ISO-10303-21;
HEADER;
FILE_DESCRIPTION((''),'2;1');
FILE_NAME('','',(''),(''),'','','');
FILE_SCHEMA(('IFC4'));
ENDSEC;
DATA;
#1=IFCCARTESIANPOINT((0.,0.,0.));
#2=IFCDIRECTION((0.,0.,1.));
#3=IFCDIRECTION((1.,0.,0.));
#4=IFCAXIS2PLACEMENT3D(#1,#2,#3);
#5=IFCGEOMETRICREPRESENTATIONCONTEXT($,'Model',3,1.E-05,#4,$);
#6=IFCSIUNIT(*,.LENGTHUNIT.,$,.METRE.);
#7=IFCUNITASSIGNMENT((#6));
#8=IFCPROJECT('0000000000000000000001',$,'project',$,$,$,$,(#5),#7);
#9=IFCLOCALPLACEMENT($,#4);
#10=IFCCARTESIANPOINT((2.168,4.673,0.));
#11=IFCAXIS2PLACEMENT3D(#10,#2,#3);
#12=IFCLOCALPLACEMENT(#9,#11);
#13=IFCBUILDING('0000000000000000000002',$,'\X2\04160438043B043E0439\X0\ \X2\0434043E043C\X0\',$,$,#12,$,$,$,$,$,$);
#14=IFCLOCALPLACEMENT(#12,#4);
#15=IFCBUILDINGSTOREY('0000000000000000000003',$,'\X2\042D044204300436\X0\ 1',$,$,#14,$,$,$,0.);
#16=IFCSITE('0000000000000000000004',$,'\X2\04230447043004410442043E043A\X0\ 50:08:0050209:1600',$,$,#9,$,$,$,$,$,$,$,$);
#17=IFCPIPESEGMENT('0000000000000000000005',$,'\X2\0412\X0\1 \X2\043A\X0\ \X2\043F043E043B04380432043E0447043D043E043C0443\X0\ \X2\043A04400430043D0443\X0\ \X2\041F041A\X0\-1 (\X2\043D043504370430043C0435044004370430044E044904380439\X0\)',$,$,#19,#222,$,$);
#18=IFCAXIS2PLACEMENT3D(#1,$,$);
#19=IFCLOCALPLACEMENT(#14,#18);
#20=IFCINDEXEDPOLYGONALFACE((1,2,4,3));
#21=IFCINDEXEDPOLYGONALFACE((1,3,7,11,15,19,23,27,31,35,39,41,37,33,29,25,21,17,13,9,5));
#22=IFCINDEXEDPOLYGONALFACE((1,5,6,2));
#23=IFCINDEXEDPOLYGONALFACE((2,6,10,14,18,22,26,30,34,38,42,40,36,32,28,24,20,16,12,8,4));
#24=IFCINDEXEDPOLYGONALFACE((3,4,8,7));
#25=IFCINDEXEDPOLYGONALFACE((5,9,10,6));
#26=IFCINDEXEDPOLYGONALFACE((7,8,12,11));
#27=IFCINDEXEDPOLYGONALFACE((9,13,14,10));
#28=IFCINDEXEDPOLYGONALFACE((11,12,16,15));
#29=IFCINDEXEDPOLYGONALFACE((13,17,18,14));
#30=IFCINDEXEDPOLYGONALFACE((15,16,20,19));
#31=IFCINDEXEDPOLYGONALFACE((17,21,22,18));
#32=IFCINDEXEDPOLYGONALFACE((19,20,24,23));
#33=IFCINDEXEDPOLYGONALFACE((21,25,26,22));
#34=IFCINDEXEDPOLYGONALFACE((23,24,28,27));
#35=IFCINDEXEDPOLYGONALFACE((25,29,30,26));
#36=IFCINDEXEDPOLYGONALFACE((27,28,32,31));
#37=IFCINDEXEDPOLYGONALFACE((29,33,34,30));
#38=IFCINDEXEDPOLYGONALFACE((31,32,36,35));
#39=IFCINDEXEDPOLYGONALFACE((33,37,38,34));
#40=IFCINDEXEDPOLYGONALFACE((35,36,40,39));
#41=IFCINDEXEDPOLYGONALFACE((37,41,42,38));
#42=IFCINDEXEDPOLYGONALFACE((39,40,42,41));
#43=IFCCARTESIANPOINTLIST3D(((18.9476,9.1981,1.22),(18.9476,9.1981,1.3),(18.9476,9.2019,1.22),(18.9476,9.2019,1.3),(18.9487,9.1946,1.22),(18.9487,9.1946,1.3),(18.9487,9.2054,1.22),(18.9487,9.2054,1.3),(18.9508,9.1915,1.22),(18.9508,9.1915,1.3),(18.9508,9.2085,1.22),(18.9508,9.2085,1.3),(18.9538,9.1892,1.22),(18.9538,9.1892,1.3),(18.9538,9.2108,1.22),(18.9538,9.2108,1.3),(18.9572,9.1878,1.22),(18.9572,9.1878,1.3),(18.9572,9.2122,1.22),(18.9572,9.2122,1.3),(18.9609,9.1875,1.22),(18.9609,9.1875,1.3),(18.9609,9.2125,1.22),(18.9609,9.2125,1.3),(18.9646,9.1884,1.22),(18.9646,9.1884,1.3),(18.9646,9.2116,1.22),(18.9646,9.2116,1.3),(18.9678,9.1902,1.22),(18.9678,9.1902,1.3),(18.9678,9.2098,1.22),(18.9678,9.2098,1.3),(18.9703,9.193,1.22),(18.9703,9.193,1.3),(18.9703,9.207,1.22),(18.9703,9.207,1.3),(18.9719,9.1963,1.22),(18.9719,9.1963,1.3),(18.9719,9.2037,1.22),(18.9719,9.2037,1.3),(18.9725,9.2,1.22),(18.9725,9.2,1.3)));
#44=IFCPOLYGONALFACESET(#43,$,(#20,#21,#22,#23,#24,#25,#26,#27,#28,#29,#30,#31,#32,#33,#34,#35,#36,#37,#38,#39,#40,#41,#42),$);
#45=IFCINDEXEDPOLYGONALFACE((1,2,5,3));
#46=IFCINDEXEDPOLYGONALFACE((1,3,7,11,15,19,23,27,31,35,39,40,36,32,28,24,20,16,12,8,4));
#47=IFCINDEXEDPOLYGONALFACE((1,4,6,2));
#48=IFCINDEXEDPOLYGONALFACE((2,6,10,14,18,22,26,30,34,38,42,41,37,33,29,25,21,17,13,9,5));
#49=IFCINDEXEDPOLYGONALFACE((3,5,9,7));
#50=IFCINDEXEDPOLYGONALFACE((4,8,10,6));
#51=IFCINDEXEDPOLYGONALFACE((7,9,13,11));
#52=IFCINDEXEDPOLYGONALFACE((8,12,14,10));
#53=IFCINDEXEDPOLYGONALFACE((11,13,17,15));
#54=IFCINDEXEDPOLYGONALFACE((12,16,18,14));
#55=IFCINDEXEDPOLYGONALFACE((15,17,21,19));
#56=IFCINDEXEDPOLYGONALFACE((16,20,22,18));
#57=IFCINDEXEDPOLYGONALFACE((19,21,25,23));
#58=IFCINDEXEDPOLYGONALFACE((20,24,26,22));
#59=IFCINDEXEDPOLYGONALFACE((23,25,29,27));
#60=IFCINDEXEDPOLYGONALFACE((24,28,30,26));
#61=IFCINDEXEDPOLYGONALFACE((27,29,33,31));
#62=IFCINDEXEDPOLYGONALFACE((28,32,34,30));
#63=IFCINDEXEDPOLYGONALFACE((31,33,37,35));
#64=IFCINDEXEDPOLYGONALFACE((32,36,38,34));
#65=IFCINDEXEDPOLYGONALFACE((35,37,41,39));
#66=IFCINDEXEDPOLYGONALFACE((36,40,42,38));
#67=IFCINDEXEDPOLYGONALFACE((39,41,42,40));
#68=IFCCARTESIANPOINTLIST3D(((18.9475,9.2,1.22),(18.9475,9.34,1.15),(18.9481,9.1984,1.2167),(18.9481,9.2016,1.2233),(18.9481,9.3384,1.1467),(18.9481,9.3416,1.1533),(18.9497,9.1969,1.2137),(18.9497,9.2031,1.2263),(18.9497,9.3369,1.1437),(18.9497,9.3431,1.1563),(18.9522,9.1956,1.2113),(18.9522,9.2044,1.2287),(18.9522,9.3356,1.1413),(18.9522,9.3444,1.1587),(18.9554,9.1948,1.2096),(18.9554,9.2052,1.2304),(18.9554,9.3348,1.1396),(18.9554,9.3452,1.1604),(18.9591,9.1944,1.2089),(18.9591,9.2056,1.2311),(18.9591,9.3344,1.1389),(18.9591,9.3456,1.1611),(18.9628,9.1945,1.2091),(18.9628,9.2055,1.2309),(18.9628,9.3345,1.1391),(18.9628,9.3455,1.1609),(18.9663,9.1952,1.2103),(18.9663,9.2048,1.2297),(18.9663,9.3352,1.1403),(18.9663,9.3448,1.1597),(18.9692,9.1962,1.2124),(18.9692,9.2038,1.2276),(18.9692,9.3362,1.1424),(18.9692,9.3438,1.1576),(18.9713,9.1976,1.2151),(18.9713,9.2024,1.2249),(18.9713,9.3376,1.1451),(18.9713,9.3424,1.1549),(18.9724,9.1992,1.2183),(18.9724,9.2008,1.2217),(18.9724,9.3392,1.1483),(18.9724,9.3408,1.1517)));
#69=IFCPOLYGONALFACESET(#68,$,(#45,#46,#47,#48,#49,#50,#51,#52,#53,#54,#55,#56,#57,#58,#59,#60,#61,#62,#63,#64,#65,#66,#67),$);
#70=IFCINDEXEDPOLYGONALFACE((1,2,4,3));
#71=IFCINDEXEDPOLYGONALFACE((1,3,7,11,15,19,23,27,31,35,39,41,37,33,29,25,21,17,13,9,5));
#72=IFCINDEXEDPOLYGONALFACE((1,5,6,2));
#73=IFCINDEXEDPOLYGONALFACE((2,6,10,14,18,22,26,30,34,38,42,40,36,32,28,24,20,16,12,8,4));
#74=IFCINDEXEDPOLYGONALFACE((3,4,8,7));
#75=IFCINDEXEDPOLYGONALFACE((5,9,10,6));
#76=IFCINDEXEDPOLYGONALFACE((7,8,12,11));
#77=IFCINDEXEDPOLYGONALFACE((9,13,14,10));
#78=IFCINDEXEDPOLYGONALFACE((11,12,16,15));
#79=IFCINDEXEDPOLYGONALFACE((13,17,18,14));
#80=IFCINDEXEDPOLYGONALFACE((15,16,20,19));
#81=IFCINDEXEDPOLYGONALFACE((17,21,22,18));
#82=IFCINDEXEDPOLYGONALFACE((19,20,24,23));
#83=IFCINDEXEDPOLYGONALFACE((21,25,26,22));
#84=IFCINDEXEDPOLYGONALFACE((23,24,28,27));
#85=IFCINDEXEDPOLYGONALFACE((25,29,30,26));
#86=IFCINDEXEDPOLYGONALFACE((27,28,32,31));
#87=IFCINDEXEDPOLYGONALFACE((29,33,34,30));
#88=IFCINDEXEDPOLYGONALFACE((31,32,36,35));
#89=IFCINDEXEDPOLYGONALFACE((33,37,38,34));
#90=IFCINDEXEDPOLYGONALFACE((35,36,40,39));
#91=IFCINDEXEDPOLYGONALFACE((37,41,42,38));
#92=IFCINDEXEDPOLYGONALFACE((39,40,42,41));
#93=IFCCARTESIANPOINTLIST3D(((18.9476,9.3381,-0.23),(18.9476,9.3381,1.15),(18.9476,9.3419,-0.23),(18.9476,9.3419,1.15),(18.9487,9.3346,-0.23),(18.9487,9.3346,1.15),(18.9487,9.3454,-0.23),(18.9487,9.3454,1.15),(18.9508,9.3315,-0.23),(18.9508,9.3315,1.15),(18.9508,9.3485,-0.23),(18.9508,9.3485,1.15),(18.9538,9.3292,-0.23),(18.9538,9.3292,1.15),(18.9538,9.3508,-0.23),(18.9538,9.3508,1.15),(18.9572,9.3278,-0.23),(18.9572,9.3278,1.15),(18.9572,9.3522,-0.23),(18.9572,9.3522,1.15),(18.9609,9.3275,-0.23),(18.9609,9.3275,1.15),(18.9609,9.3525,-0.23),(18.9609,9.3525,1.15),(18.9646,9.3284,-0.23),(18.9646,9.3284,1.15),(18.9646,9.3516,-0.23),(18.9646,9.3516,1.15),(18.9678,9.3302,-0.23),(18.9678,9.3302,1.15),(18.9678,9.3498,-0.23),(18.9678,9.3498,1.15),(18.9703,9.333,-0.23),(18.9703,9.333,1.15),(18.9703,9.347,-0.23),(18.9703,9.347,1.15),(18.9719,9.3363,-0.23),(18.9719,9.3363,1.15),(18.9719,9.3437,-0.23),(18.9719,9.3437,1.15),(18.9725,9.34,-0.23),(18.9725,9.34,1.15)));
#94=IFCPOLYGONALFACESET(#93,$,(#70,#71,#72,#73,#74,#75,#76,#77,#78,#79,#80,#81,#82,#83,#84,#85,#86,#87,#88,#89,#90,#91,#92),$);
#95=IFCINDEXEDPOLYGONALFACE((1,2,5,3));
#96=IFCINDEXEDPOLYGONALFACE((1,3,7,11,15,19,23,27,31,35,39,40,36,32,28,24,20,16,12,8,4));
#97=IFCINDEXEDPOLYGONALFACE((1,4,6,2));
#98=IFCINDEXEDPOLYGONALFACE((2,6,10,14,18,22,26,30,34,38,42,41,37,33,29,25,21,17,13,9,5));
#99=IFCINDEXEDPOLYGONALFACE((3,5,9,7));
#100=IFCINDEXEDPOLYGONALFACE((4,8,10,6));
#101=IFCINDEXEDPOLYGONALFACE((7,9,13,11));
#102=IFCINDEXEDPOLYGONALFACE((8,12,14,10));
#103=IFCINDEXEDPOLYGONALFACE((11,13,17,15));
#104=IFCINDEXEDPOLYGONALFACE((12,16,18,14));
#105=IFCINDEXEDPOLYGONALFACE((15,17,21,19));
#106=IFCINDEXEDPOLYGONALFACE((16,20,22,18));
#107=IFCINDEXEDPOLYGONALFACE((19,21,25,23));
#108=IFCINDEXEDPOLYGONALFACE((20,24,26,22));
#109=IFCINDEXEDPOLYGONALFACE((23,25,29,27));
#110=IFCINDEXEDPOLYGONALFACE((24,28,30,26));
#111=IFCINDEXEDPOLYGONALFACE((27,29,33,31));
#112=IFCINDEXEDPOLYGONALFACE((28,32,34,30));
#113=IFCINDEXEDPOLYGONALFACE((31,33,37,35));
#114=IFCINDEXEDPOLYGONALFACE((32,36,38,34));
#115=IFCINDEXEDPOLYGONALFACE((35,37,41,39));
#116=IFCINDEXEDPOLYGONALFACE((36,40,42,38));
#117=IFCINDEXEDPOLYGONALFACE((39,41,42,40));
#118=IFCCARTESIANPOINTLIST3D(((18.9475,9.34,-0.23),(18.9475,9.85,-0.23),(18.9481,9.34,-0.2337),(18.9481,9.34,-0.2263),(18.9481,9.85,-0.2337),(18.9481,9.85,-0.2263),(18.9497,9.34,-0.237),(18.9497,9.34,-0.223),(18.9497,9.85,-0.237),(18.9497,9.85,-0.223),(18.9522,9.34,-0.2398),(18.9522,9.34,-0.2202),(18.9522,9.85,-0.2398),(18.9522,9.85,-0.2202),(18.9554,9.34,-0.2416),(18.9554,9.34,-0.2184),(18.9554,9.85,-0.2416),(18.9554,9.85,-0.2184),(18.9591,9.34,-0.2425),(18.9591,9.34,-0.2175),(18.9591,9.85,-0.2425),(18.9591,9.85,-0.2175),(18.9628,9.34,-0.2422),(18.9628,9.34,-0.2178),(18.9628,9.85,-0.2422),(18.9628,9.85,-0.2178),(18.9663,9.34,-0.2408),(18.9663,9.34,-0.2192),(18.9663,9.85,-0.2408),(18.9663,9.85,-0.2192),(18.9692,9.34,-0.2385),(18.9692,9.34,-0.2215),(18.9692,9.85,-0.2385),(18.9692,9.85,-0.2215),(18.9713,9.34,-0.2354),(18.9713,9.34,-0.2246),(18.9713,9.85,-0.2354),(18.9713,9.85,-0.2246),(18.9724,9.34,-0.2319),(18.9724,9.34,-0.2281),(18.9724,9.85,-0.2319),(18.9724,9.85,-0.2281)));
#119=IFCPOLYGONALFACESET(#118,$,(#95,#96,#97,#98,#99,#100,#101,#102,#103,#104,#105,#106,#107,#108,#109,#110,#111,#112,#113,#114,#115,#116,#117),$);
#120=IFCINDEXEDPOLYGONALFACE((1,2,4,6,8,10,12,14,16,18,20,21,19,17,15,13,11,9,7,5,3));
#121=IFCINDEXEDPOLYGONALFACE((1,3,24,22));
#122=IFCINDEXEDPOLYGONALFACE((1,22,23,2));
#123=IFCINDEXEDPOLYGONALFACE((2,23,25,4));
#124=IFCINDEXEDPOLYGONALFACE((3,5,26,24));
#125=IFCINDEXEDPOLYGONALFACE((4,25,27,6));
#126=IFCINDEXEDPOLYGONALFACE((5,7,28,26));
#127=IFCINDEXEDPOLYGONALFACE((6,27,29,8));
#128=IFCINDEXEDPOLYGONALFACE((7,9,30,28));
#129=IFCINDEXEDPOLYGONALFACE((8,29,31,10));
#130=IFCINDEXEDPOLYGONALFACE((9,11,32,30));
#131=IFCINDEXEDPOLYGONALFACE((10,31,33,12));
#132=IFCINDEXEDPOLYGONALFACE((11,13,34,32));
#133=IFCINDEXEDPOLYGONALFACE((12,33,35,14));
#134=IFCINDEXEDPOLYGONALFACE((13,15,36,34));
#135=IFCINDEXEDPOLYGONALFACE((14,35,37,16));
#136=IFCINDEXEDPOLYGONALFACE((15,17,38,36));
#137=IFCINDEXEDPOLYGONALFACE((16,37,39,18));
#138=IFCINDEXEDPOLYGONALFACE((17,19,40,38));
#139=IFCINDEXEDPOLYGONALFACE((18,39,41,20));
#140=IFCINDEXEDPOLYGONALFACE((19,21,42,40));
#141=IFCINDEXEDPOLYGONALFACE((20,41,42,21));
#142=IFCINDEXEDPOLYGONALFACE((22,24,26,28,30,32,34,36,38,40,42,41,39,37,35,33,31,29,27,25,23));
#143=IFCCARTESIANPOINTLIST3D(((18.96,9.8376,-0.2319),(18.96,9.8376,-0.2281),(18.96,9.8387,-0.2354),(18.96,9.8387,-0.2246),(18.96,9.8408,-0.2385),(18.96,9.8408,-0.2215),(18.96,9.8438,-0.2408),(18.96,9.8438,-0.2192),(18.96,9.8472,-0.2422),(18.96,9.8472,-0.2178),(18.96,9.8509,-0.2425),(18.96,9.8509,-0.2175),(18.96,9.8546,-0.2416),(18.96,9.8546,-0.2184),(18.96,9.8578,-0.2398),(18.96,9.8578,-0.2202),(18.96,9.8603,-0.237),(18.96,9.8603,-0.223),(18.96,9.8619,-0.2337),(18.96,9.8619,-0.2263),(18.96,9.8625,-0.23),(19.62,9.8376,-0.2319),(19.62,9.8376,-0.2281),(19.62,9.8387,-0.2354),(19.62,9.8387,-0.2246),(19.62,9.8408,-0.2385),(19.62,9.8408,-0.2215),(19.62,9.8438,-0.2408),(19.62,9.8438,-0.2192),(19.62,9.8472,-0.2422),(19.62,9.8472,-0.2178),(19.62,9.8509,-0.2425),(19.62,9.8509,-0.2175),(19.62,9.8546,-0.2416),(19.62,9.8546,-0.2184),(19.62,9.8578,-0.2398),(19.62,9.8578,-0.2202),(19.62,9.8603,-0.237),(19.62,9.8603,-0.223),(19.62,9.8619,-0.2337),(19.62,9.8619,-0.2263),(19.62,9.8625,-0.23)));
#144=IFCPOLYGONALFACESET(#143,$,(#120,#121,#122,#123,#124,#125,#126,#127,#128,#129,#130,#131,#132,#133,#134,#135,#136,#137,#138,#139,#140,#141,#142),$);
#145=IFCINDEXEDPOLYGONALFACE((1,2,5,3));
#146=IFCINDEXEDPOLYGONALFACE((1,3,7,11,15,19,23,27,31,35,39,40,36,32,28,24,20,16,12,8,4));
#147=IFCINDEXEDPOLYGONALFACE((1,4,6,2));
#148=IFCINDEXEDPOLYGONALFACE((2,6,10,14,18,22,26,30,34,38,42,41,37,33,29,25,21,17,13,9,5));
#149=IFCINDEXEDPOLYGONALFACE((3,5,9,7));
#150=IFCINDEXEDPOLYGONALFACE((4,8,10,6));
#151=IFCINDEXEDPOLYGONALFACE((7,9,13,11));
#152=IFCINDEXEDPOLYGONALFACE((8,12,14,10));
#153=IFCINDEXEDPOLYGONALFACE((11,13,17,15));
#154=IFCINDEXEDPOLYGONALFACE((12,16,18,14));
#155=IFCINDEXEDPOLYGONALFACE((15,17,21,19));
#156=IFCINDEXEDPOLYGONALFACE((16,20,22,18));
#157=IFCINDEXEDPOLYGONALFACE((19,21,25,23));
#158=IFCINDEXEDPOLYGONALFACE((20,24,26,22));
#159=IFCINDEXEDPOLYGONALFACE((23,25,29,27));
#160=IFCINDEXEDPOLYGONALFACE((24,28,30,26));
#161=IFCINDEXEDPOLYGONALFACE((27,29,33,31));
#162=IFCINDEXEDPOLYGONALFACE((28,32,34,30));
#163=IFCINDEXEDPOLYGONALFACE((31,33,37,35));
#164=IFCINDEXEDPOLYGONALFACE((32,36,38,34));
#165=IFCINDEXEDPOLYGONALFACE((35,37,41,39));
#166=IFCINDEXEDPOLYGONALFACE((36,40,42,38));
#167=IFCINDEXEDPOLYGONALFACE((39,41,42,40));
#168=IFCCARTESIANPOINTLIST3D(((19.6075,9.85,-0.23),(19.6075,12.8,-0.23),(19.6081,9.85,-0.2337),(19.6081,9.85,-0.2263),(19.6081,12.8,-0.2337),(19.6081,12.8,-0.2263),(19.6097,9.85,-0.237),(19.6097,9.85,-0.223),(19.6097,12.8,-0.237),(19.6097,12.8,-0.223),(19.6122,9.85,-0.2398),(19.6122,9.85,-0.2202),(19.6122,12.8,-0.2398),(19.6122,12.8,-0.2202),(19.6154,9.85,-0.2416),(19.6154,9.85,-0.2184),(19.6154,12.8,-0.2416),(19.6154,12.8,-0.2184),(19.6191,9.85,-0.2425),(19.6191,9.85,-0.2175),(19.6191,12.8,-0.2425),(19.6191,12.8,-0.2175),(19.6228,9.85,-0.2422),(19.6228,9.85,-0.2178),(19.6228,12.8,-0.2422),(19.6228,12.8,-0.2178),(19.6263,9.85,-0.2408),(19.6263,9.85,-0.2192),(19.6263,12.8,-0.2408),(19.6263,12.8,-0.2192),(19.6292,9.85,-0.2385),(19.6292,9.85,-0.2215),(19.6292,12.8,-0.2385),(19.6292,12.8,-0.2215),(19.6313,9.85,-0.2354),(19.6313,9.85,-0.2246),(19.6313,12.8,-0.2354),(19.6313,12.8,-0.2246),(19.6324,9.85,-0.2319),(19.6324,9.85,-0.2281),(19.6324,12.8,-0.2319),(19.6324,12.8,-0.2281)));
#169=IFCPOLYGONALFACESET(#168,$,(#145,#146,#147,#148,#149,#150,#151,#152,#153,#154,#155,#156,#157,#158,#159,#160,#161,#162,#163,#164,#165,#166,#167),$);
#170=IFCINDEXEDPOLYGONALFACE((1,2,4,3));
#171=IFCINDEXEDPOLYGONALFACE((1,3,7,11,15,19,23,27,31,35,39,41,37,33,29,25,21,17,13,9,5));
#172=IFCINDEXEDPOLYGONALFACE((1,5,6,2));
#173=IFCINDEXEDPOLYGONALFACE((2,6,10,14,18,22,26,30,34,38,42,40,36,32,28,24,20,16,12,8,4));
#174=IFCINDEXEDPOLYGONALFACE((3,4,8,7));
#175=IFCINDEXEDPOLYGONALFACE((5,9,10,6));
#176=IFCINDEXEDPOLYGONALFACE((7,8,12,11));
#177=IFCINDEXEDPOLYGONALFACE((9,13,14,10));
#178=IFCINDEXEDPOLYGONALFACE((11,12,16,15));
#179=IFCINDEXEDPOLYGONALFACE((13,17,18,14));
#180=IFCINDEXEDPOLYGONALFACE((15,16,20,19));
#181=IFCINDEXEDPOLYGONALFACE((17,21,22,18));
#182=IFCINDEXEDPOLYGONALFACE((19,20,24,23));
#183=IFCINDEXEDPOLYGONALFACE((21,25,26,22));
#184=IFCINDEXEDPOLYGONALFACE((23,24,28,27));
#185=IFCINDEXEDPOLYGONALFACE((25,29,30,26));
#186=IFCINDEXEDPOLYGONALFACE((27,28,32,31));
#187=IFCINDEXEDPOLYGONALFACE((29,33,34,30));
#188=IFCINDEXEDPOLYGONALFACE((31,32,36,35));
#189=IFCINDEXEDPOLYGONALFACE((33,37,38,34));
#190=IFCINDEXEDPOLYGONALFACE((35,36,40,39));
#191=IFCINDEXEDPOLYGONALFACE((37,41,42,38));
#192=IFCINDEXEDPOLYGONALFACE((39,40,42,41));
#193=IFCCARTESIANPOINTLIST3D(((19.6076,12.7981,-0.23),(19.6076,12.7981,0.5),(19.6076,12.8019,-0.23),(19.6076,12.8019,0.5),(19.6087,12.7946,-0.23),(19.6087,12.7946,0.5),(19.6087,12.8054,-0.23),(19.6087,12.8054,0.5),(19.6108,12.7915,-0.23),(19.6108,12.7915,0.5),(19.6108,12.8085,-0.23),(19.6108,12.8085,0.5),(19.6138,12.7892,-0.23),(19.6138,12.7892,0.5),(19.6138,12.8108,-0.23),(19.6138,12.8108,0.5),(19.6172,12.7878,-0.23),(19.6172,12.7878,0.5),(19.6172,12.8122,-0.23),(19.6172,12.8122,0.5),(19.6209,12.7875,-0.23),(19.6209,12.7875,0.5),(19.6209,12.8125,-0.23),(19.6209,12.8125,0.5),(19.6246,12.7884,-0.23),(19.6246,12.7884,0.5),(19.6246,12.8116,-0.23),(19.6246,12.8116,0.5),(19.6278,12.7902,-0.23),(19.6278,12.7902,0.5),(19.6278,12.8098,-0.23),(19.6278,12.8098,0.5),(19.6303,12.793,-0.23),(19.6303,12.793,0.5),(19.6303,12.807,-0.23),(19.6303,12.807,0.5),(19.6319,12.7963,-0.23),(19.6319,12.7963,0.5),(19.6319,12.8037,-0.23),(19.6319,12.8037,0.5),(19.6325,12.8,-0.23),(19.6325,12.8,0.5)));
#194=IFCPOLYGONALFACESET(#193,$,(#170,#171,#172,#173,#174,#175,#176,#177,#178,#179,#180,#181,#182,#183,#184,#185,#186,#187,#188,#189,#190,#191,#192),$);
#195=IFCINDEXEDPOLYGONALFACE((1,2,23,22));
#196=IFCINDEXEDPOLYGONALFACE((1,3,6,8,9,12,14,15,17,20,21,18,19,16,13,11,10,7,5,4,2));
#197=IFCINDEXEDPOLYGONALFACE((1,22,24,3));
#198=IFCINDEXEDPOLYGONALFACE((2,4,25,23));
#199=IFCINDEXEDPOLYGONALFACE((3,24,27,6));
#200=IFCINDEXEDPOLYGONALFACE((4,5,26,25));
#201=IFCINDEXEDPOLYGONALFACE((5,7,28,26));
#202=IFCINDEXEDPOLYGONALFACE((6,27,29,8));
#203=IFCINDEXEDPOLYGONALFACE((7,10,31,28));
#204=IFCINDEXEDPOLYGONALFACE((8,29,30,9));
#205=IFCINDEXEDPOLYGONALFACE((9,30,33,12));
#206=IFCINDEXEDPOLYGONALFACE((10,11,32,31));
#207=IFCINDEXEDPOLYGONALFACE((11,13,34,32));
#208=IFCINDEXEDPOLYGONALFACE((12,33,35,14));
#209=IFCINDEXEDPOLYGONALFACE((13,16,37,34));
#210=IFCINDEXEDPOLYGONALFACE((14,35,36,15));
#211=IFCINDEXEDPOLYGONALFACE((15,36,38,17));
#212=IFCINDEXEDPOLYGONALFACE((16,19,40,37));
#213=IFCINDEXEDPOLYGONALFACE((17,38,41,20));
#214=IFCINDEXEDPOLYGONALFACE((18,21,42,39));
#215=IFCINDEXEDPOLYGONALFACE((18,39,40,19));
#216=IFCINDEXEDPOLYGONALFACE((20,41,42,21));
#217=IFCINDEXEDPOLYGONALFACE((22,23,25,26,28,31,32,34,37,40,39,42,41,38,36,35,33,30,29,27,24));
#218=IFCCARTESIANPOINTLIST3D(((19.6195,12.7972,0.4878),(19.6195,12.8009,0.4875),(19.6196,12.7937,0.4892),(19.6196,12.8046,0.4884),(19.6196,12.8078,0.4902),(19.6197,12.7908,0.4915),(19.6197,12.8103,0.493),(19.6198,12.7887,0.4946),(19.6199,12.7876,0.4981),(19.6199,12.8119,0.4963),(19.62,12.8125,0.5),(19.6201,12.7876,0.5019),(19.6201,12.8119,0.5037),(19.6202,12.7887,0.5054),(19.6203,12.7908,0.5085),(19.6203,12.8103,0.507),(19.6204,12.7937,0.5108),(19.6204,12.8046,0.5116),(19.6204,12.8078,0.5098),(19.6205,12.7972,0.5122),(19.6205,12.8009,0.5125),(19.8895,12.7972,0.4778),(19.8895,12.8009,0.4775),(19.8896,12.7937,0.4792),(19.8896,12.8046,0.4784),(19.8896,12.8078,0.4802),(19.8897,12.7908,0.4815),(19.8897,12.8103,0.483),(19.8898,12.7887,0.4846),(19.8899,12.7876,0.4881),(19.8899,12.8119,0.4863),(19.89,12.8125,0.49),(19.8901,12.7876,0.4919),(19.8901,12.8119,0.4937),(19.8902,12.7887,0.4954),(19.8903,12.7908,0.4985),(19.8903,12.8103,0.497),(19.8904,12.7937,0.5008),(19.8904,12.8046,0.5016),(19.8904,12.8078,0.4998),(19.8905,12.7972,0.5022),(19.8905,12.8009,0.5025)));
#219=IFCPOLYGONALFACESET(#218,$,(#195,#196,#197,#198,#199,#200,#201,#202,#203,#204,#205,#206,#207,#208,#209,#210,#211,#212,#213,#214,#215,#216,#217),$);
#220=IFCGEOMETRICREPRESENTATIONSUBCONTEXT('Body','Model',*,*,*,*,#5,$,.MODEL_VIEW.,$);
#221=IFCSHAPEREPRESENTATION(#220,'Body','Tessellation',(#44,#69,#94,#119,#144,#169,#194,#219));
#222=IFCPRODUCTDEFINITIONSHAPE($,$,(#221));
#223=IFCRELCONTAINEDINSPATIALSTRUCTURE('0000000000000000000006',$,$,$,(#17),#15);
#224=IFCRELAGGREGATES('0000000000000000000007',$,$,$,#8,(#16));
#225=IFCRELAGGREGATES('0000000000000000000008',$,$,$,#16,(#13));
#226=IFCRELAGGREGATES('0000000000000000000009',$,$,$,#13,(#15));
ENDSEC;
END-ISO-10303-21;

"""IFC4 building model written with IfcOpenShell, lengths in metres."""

from ifc_helpers import new_model, si_unit, frame, origin_with_axes, origin_2d, place, context, subcontext, project, spatial, circle, extrude, element, save


model = new_model("IFC4")

# Units and contexts
model_context = context("Model", 3, precision=1e-05, world=origin_with_axes())
body_context = subcontext(model_context, "Body", "Model", "MODEL_VIEW")
ifc_project = project(units=[si_unit("LENGTHUNIT", "METRE")], contexts=[model_context])

# Site, building, storey
site_placement = place(None, origin_with_axes())
site = spatial("IfcSite", under=ifc_project, at=site_placement, Name="Участок 50:08:0050209:1600")
building_placement = place(site_placement, frame((2.168, 4.673, 0.0), z_axis=(0.0, 0.0, 1.0), x_axis=(1.0, 0.0, 0.0)))
building = spatial("IfcBuilding", under=site, at=building_placement, Name="Жилой дом")
storey_placement = place(building_placement, origin_with_axes())
storey = spatial("IfcBuildingStorey", under=building, at=storey_placement, Name="Этаж 1", Elevation=0.0)

# Pipe segment
pipe_segment_1_placement = place(storey_placement, origin_with_axes())
element("IfcPipeSegment", 1, at=pipe_segment_1_placement, inside=storey, Name="В1 к поливочному крану ПК-1 (незамерзающий)", context=body_context, shape_type="SweptSolid", body=[
    extrude(circle(Radius=0.0125, at=origin_2d()), frame((18.96, 9.2, 1.3), z_axis=(0.0, 0.0, -1.0), x_axis=(1.0, 0.0, 0.0)), (0.0, 0.0, 1.0), 0.08),
    extrude(circle(Radius=0.0125, at=origin_2d()), frame((18.96, 9.2, 1.22), z_axis=(0.0, 0.894427, -0.447214), x_axis=(-1.0, 0.0, 0.0)), (0.0, 0.0, 1.0), 0.1565),
    extrude(circle(Radius=0.0125, at=origin_2d()), frame((18.96, 9.34, 1.15), z_axis=(0.0, 0.0, -1.0), x_axis=(1.0, 0.0, 0.0)), (0.0, 0.0, 1.0), 1.38),
    extrude(circle(Radius=0.0125, at=origin_2d()), frame((18.96, 9.34, -0.23), z_axis=(0.0, 1.0, 0.0), x_axis=(-1.0, 0.0, 0.0)), (0.0, 0.0, 1.0), 0.51),
    extrude(circle(Radius=0.0125, at=origin_2d()), frame((18.96, 9.85, -0.23), z_axis=(1.0, 0.0, 0.0), x_axis=(0.0, 1.0, 0.0)), (0.0, 0.0, 1.0), 0.66),
    extrude(circle(Radius=0.0125, at=origin_2d()), frame((19.62, 9.85, -0.23), z_axis=(0.0, 1.0, 0.0), x_axis=(-1.0, 0.0, 0.0)), (0.0, 0.0, 1.0), 2.95),
    extrude(circle(Radius=0.0125, at=origin_2d()), frame((19.62, 12.8, -0.23), z_axis=(0.0, 0.0, 1.0), x_axis=(1.0, 0.0, 0.0)), (0.0, 0.0, 1.0), 0.73),
    extrude(circle(Radius=0.0125, at=origin_2d()), frame((19.62, 12.8, 0.5), z_axis=(0.999315, 0.0, -0.037012), x_axis=(0.0, 1.0, 0.0)), (0.0, 0.0, 1.0), 0.2702),
])

save(model, "model.ifc")
